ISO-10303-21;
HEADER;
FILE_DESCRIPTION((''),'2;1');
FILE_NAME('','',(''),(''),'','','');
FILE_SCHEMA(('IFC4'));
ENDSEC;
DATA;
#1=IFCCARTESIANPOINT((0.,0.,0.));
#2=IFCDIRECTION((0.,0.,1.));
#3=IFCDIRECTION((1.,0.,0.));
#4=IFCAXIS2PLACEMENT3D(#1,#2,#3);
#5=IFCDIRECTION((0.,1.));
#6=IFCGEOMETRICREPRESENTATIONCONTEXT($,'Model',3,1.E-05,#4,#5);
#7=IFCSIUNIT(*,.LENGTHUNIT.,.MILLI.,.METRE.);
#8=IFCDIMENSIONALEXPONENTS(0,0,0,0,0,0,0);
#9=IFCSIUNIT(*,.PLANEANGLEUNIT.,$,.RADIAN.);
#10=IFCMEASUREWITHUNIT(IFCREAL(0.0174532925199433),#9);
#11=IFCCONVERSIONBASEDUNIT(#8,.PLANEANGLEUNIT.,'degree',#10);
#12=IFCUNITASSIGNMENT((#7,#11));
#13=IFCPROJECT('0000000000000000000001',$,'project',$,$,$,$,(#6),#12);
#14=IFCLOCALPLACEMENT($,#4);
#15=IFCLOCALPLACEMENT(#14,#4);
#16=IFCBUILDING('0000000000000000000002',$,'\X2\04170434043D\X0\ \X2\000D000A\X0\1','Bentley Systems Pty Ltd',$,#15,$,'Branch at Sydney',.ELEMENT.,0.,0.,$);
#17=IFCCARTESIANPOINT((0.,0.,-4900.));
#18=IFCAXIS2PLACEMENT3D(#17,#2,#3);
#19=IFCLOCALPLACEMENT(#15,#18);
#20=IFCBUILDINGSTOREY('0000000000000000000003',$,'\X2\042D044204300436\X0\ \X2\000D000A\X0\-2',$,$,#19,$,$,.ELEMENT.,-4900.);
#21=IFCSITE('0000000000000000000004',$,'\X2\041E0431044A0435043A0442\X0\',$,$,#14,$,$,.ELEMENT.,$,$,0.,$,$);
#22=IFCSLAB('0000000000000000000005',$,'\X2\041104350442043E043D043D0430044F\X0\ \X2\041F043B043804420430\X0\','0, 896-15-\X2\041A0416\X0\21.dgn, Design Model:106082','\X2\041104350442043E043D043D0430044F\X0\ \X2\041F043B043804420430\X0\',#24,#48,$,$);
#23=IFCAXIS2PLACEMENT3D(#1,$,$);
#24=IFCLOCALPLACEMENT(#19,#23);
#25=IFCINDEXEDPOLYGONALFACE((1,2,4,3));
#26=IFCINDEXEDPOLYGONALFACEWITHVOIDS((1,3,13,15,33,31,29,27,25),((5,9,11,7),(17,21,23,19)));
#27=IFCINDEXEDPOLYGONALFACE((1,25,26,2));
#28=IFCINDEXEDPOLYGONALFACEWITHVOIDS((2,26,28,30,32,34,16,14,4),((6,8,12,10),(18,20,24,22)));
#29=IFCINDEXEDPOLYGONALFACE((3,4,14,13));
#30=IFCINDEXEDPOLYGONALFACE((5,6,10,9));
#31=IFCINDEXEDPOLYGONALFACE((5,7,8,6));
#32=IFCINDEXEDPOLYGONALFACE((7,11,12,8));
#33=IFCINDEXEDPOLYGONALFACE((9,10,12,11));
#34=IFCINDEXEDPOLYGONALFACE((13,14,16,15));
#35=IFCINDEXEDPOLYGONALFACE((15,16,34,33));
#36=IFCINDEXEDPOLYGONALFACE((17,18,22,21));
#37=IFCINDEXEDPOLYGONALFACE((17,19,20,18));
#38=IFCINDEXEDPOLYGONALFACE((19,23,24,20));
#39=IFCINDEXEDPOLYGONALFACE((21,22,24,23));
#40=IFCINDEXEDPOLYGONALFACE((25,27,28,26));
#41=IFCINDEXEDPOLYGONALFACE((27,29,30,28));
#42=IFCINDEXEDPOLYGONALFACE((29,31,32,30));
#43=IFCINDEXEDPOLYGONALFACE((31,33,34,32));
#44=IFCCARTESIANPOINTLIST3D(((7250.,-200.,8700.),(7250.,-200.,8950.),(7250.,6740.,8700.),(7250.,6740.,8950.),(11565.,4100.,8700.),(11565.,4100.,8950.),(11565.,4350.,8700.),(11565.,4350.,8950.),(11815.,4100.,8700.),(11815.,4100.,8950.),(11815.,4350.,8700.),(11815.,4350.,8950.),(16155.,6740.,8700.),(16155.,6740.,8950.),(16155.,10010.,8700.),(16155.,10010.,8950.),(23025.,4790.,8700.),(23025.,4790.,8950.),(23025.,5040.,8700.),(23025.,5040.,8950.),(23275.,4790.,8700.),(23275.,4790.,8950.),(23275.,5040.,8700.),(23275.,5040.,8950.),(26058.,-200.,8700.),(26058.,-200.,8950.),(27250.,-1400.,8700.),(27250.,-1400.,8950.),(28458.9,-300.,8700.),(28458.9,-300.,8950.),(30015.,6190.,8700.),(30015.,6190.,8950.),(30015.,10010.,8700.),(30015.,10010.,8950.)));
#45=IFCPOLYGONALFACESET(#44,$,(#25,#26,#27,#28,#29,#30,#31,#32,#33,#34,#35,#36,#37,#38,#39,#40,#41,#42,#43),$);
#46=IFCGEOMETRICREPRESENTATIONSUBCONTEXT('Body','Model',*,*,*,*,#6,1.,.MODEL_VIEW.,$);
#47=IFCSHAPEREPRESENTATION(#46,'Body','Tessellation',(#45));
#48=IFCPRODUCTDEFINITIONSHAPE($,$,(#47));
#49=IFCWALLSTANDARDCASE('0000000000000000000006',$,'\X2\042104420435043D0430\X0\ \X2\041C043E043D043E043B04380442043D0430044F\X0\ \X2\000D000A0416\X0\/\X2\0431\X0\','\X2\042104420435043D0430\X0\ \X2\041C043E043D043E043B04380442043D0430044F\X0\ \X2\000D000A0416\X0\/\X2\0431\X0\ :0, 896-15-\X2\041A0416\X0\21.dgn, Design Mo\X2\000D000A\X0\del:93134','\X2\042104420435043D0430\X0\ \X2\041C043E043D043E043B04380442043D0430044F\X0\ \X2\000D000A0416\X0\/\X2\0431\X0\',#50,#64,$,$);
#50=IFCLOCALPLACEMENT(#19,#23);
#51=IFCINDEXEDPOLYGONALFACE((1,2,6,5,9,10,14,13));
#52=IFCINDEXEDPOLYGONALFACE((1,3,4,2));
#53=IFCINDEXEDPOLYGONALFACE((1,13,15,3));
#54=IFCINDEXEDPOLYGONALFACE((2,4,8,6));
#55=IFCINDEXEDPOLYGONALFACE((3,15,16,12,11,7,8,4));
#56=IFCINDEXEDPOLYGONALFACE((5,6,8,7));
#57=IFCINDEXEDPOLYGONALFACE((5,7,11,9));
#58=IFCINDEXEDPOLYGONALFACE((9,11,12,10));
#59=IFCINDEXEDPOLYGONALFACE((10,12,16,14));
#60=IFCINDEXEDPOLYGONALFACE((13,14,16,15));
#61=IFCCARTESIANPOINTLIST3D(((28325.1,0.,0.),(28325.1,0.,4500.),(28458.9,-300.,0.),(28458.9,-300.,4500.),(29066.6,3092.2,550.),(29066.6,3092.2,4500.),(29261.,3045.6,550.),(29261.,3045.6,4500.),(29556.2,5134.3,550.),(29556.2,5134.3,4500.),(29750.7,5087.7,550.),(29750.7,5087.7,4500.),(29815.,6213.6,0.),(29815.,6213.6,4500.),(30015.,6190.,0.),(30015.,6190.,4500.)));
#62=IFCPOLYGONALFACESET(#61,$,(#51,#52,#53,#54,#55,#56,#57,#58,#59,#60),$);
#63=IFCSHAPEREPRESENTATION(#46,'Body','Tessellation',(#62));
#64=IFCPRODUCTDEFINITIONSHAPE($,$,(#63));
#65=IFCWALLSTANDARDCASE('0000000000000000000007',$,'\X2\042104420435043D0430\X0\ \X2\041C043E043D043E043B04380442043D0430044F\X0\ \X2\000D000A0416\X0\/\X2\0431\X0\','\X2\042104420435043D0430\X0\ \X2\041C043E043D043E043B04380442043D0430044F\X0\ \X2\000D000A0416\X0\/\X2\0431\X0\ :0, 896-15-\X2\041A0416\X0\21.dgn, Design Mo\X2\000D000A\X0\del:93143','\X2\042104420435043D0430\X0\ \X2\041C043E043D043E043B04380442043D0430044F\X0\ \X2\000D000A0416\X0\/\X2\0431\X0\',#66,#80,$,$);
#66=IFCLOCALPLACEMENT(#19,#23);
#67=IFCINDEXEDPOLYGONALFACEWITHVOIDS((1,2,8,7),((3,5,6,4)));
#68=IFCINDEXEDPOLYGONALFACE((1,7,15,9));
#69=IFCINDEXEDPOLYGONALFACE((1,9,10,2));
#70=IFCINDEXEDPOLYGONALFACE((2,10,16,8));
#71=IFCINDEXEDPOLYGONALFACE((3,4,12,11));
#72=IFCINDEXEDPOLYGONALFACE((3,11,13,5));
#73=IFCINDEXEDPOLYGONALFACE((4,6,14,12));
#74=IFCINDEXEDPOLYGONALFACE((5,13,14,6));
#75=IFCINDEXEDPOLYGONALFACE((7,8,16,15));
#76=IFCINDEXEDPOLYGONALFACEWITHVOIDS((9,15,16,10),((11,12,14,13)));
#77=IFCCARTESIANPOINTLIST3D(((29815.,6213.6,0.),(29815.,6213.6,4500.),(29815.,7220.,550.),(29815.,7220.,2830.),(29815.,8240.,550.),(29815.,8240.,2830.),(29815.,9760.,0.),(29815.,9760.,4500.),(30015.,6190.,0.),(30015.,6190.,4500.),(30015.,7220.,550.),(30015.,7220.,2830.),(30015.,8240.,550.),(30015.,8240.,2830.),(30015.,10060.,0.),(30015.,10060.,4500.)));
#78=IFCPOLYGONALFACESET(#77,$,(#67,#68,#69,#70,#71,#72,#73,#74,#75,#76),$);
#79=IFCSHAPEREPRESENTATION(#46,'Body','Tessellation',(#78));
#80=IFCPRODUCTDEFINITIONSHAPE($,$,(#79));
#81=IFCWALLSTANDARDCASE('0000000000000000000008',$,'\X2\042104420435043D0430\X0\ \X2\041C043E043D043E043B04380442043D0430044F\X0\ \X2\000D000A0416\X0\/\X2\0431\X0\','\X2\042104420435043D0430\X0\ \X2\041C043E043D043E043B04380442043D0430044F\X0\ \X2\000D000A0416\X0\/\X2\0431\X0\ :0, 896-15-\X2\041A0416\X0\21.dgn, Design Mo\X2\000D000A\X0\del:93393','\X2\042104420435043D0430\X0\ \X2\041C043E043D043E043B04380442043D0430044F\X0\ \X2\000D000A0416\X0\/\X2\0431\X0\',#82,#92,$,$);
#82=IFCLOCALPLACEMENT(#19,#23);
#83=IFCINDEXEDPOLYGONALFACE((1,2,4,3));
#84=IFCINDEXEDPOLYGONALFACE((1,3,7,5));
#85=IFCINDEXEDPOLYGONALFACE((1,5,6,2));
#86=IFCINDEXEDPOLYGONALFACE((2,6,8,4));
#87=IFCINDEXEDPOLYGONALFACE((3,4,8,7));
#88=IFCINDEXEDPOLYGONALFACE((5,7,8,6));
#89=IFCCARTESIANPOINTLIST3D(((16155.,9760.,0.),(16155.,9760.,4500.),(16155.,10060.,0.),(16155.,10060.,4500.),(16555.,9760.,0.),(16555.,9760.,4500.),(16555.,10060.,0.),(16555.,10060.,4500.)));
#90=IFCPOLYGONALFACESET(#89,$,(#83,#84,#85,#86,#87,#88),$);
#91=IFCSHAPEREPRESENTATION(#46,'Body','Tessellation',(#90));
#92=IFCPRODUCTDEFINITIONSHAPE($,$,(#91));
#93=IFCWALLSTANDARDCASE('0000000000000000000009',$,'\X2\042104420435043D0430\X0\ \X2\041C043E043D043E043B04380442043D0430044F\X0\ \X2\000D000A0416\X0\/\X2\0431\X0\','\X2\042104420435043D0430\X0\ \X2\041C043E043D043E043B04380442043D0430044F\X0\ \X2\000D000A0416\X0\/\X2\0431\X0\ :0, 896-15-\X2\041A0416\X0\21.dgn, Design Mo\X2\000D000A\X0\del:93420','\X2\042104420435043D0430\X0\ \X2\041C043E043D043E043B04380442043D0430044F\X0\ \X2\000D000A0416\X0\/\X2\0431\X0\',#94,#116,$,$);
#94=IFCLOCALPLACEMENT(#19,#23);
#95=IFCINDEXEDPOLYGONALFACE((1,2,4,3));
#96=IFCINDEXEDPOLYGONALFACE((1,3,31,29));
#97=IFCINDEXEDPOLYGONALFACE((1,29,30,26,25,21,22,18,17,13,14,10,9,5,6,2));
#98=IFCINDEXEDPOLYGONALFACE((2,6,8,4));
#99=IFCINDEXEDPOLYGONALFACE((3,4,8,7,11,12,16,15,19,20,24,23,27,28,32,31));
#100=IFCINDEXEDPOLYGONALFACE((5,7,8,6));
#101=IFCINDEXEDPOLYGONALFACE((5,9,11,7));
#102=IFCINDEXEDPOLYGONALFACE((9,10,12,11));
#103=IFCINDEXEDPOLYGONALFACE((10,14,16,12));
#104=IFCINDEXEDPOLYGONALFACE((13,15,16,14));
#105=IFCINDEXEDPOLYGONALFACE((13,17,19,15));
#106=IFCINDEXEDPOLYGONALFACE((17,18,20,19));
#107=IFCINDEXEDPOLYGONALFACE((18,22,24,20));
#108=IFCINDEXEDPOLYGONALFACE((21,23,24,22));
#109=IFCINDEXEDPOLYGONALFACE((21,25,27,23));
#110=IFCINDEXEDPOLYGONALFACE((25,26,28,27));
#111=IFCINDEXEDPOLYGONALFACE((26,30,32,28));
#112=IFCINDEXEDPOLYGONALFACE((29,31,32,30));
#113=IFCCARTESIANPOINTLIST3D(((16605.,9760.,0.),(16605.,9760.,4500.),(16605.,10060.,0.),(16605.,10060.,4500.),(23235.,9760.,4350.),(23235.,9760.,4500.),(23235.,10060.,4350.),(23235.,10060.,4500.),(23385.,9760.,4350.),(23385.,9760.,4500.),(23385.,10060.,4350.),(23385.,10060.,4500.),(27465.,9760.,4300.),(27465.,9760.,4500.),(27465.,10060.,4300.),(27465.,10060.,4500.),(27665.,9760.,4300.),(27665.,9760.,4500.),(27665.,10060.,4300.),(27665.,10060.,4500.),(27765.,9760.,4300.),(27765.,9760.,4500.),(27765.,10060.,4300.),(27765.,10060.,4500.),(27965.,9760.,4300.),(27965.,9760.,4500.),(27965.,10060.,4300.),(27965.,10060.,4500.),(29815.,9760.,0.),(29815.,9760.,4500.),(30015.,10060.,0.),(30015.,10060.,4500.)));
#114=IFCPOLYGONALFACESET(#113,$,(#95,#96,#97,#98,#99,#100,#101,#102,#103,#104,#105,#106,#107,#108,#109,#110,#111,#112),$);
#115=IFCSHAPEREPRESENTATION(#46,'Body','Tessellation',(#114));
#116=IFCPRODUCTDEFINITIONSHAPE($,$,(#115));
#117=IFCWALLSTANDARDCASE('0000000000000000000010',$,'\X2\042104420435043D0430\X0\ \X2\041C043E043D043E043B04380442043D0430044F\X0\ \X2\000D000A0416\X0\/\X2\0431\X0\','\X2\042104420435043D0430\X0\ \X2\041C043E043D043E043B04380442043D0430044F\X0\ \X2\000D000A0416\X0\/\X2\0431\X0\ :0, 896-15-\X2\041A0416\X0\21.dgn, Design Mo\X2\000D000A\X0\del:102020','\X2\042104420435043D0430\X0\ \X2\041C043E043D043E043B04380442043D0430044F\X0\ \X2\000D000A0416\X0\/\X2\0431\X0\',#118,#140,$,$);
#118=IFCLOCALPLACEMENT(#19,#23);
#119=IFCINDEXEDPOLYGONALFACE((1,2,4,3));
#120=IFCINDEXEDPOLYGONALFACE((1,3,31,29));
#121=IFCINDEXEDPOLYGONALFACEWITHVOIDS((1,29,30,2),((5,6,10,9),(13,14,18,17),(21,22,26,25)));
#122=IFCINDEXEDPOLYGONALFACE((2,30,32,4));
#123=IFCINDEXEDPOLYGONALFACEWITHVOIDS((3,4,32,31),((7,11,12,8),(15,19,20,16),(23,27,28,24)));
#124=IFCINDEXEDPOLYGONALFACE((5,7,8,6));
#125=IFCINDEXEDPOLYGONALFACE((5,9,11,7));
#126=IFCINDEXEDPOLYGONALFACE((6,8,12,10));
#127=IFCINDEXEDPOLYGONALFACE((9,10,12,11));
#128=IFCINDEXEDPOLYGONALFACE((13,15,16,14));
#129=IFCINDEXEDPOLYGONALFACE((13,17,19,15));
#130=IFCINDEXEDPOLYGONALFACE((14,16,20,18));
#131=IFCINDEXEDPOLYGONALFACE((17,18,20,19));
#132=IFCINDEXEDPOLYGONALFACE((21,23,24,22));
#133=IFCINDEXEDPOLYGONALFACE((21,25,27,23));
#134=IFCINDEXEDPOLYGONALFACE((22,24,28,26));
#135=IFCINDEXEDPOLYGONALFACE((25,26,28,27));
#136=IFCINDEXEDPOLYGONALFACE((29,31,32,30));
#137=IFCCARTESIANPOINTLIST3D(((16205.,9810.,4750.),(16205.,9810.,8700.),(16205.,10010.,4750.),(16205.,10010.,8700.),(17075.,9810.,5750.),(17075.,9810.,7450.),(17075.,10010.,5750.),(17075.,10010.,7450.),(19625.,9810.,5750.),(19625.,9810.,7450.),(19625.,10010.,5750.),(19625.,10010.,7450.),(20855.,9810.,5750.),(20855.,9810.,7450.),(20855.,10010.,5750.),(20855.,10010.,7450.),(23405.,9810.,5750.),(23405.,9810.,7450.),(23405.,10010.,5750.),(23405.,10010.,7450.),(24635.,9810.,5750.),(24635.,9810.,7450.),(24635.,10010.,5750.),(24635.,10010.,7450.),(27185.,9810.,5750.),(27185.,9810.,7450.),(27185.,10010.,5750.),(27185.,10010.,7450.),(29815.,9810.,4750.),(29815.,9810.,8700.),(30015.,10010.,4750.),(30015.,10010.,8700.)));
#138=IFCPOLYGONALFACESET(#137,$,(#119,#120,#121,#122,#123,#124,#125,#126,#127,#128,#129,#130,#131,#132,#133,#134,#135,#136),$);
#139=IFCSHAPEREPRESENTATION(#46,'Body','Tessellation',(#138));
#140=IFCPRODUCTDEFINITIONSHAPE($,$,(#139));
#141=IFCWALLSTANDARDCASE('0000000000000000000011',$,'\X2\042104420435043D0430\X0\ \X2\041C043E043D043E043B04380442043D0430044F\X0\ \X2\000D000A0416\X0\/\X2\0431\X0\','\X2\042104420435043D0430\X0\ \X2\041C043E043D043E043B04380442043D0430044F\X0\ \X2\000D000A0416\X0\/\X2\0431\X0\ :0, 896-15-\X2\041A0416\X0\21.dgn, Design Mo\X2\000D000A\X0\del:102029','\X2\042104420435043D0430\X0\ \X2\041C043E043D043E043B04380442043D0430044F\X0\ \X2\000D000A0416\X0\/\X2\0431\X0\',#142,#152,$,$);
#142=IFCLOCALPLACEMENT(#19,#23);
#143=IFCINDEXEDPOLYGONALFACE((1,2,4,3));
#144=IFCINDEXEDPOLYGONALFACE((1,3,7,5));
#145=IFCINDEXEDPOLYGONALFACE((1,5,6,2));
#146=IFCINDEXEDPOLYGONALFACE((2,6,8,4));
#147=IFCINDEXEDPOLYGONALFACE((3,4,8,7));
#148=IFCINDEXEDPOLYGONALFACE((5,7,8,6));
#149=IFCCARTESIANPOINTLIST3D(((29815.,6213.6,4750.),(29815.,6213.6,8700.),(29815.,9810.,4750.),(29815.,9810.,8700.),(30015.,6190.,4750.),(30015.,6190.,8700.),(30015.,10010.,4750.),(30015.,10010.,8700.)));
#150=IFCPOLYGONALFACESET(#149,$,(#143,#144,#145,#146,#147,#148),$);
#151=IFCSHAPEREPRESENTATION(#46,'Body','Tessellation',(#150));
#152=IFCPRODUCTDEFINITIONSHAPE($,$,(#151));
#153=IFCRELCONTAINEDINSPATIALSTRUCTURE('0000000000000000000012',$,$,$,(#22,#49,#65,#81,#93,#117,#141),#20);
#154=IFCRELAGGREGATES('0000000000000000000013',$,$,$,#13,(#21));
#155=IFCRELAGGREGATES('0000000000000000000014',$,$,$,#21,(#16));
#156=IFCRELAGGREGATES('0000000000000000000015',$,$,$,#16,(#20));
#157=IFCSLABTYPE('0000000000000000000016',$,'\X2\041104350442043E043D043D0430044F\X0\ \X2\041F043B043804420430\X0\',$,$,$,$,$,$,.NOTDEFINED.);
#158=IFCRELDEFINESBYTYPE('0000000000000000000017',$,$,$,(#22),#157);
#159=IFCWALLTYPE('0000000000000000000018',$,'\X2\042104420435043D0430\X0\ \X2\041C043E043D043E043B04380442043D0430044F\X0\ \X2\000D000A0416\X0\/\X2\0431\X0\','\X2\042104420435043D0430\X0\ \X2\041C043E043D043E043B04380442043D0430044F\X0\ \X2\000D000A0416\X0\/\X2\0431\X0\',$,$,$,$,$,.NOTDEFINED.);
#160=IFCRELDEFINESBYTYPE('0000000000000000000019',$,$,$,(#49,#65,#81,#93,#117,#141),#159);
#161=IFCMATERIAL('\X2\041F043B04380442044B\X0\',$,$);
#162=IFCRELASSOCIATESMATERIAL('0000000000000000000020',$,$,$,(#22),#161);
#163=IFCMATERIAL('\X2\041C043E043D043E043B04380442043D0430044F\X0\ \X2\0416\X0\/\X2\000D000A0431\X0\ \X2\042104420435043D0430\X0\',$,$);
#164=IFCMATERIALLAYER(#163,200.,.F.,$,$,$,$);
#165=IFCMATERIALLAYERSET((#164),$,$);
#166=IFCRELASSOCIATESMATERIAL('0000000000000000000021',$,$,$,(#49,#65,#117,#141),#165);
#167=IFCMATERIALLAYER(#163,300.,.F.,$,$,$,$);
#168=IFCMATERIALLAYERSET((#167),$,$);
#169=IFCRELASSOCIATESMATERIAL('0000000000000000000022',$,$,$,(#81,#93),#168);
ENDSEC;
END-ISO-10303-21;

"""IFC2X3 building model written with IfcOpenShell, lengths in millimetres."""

from ifc_helpers import new_model, entity, si_unit, converted_unit, direction, frame, frame_2d, origin_with_axes, place, context, subcontext, project, spatial, polyline, rectangle, outline, extrude, material, layer, layer_set, layer_usage, type_object, element, save


model = new_model("IFC2X3")

# Units and contexts
model_context = context("Model", 3, precision=1e-05, world=origin_with_axes(), true_north=direction((0.0, 1.0)))
body_context = subcontext(model_context, "Body", "Model", "MODEL_VIEW", scale=1.0)
ifc_project = project(units=[si_unit("LENGTHUNIT", "METRE", prefix="MILLI"), converted_unit("PLANEANGLEUNIT", "degree", entity("IfcReal", 0.0174532925199433), si_unit("PLANEANGLEUNIT", "RADIAN"), dimensions=[0, 0, 0, 0, 0, 0, 0])], contexts=[model_context])

# Site, building, storey
site_placement = place(None, origin_with_axes())
site = spatial("IfcSite", under=ifc_project, at=site_placement, Name="Объект", CompositionType="ELEMENT", RefElevation=0.0)
building_placement = place(site_placement, origin_with_axes())
building = spatial("IfcBuilding", under=site, at=building_placement, Name="Здн \r\n1", Description="Bentley Systems Pty Ltd", LongName="Branch at Sydney", CompositionType="ELEMENT", ElevationOfRefHeight=0.0, ElevationOfTerrain=0.0)
storey_placement = place(building_placement, frame((0.0, 0.0, -4900.0), z_axis=(0.0, 0.0, 1.0), x_axis=(1.0, 0.0, 0.0)))
storey = spatial("IfcBuildingStorey", under=building, at=storey_placement, Name="Этаж \r\n-2", CompositionType="ELEMENT", Elevation=-4900.0)

# Slab, openings
ifc_material_1 = material(Name="Плиты")
slab_type = type_object("IfcSlabType", Name="Бетонная Плита", PredefinedType="NOTDEFINED")
slab_placement = place(storey_placement, frame((30015.0, 10010.0, 8950.0), z_axis=(0.0, 0.0, -1.0), x_axis=(0.0, -1.0, 0.0)))
slab = element("IfcSlab", 1, at=slab_placement, inside=storey, type_object=slab_type, material=ifc_material_1, Name="Бетонная Плита", Description="0, 896-15-КЖ21.dgn, Design Model:106082", ObjectType="Бетонная Плита", context=body_context, shape_type="SweptSolid", body=[
    extrude(outline(polyline([(0.0, 0.0), (3820.0, 0.0), (10310.0, 1556.1), (11410.0, 2765.0), (10210.0, 3957.0), (10210.0, 22765.0), (3270.0, 22765.0), (3270.0, 13860.0), (0.0, 13860.0), (0.0, 0.0)])), origin_with_axes(), (0.0, 0.0, 1.0), 250.0),
])
opening_1_placement = place(slab_placement, frame((4970.0, 6740.0, 0.0), z_axis=(0.0, 0.0, 1.0), x_axis=(1.0, 0.0, 0.0)))
element("IfcOpeningElement", 2, at=opening_1_placement, cuts=slab, ObjectType="Opening", context=body_context, shape_type="SweptSolid", body=[
    extrude(rectangle(XDim=250.0, YDim=250.0, at=frame_2d((-125.0, 125.0), x_axis=(0.0, 1.0))), frame((0.0, 0.0, 375.0), z_axis=(0.0, 0.0, -1.0), x_axis=(-1.0, 0.0, 0.0)), (0.0, 0.0, 1.0), 750.0),
])
opening_2_placement = place(slab_placement, frame((5660.0, 18200.0, 0.0), z_axis=(0.0, 0.0, 1.0), x_axis=(1.0, 0.0, 0.0)))
element("IfcOpeningElement", 3, at=opening_2_placement, cuts=slab, ObjectType="Opening", context=body_context, shape_type="SweptSolid", body=[
    extrude(rectangle(XDim=250.0, YDim=250.0, at=frame_2d((-125.0, 125.0), x_axis=(0.0, 1.0))), frame((0.0, 0.0, 375.0), z_axis=(0.0, 0.0, -1.0), x_axis=(-1.0, 0.0, 0.0)), (0.0, 0.0, 1.0), 750.0),
])

# Walls, openings
ifc_material_2 = material(Name="Монолитная Ж/\r\nб Стена")
ifc_layer_1 = layer(ifc_material_2, 200.0, ventilated=False)
ifc_layer_set_1 = layer_set([ifc_layer_1])
ifc_layer_usage_1 = layer_usage(ifc_layer_set_1, "AXIS2", "POSITIVE", 0.0)
wall_type = type_object("IfcWallType", Name="Стена Монолитная \r\nЖ/б", Description="Стена Монолитная \r\nЖ/б", PredefinedType="NOTDEFINED")
wall_1_placement = place(storey_placement, frame((28458.9, -300.0, 0.0), z_axis=(0.0, 0.0, 1.0), x_axis=(0.233165, 0.972437, 0.0)))
wall_1 = element("IfcWallStandardCase", 4, at=wall_1_placement, inside=storey, type_object=wall_type, material=ifc_layer_usage_1, Name="Стена Монолитная \r\nЖ/б", Description="Стена Монолитная \r\nЖ/б :0, 896-15-КЖ21.dgn, Design Mo\r\ndel:93134", ObjectType="Стена Монолитная \r\nЖ/б", context=body_context, shape_type="SweptSolid", body=[
    extrude(outline(polyline([(6650.3, 200.0), (260.5, 200.0), (0.0, 0.0), (6674.0, 0.0), (6650.3, 200.0)])), origin_with_axes(), (0.0, 0.0, 1.0), 4500.0),
])
opening_3_placement = place(wall_1_placement, frame((3440.4, 0.0, 550.0), z_axis=(0.0, 0.0, 1.0), x_axis=(1.0, 0.0, 0.0)))
element("IfcOpeningElement", 5, at=opening_3_placement, cuts=wall_1, ObjectType="Opening", context=body_context, shape_type="SweptSolid", body=[
    extrude(rectangle(XDim=3950.0, YDim=2100.0, at=frame_2d((-1050.0, 1975.0), x_axis=(0.0, -1.0))), frame((0.0, 0.0, 0.0), z_axis=(0.0, 1.0, 0.0), x_axis=(-1.0, 0.0, 0.0)), (0.0, 0.0, 1.0), 200.0),
])
wall_2_placement = place(storey_placement, frame((30015.0, 6190.0, 0.0), z_axis=(0.0, 0.0, 1.0), x_axis=(0.0, 1.0, 0.0)))
wall_2 = element("IfcWallStandardCase", 6, at=wall_2_placement, inside=storey, type_object=wall_type, material=ifc_layer_usage_1, Name="Стена Монолитная \r\nЖ/б", Description="Стена Монолитная \r\nЖ/б :0, 896-15-КЖ21.dgn, Design Mo\r\ndel:93143", ObjectType="Стена Монолитная \r\nЖ/б", context=body_context, shape_type="SweptSolid", body=[
    extrude(outline(polyline([(3570.0, 200.0), (23.6, 200.0), (0.0, 0.0), (3870.0, 0.0), (3570.0, 200.0)])), origin_with_axes(), (0.0, 0.0, 1.0), 4500.0),
])
opening_4_placement = place(wall_2_placement, frame((1030.0, 0.0, 550.0), z_axis=(0.0, 0.0, 1.0), x_axis=(1.0, 0.0, 0.0)))
element("IfcOpeningElement", 7, at=opening_4_placement, cuts=wall_2, ObjectType="Opening", context=body_context, shape_type="SweptSolid", body=[
    extrude(rectangle(XDim=2280.0, YDim=1020.0, at=frame_2d((-510.0, 1140.0), x_axis=(0.0, -1.0))), frame((0.0, 0.0, 0.0), z_axis=(0.0, 1.0, 0.0), x_axis=(-1.0, 0.0, 0.0)), (0.0, 0.0, 1.0), 200.0),
])

# Wall
ifc_layer_2 = layer(ifc_material_2, 300.0, ventilated=False)
ifc_layer_set_2 = layer_set([ifc_layer_2])
ifc_layer_usage_2 = layer_usage(ifc_layer_set_2, "AXIS2", "POSITIVE", 0.0)
wall_3_placement = place(storey_placement, frame((16555.0, 10060.0, 0.0), z_axis=(0.0, 0.0, 1.0), x_axis=(-1.0, 0.0, 0.0)))
element("IfcWallStandardCase", 8, at=wall_3_placement, inside=storey, type_object=wall_type, material=ifc_layer_usage_2, Name="Стена Монолитная \r\nЖ/б", Description="Стена Монолитная \r\nЖ/б :0, 896-15-КЖ21.dgn, Design Mo\r\ndel:93393", ObjectType="Стена Монолитная \r\nЖ/б", context=body_context, shape_type="SweptSolid", body=[
    extrude(rectangle(XDim=400.0, YDim=300.0, at=frame_2d((200.0, 150.0), x_axis=(1.0, 0.0))), origin_with_axes(), (0.0, 0.0, 1.0), 4500.0),
])

# Walls, openings
wall_4_placement = place(storey_placement, frame((30015.0, 10060.0, 0.0), z_axis=(0.0, 0.0, 1.0), x_axis=(-1.0, 0.0, 0.0)))
wall_4 = element("IfcWallStandardCase", 9, at=wall_4_placement, inside=storey, type_object=wall_type, material=ifc_layer_usage_2, Name="Стена Монолитная \r\nЖ/б", Description="Стена Монолитная \r\nЖ/б :0, 896-15-КЖ21.dgn, Design Mo\r\ndel:93420", ObjectType="Стена Монолитная \r\nЖ/б", context=body_context, shape_type="SweptSolid", body=[
    extrude(outline(polyline([(200.0, 300.0), (0.0, 0.0), (13410.0, 0.0), (13410.0, 300.0), (200.0, 300.0)])), origin_with_axes(), (0.0, 0.0, 1.0), 4500.0),
])
opening_5_placement = place(wall_4_placement, frame((6630.0, 0.0, 4350.0), z_axis=(0.0, 0.0, 1.0), x_axis=(1.0, 0.0, 0.0)))
element("IfcOpeningElement", 10, at=opening_5_placement, cuts=wall_4, ObjectType="Opening", context=body_context, shape_type="SweptSolid", body=[
    extrude(rectangle(XDim=150.0, YDim=150.0, at=frame_2d((-75.0, 75.0), x_axis=(0.0, -1.0))), frame((0.0, 0.0, 0.0), z_axis=(0.0, 1.0, 0.0), x_axis=(-1.0, 0.0, 0.0)), (0.0, 0.0, 1.0), 300.0),
])
opening_6_placement = place(wall_4_placement, frame((2350.0, 0.0, 4300.0), z_axis=(0.0, 0.0, 1.0), x_axis=(1.0, 0.0, 0.0)))
element("IfcOpeningElement", 11, at=opening_6_placement, cuts=wall_4, ObjectType="Opening", context=body_context, shape_type="SweptSolid", body=[
    extrude(rectangle(XDim=200.0, YDim=200.0, at=frame_2d((-100.0, 100.0), x_axis=(0.0, -1.0))), frame((0.0, 0.0, 0.0), z_axis=(0.0, 1.0, 0.0), x_axis=(-1.0, 0.0, 0.0)), (0.0, 0.0, 1.0), 300.0),
])
opening_7_placement = place(wall_4_placement, frame((2050.0, 0.0, 4300.0), z_axis=(0.0, 0.0, 1.0), x_axis=(1.0, 0.0, 0.0)))
element("IfcOpeningElement", 12, at=opening_7_placement, cuts=wall_4, ObjectType="Opening", context=body_context, shape_type="SweptSolid", body=[
    extrude(rectangle(XDim=200.0, YDim=200.0, at=frame_2d((-100.0, 100.0), x_axis=(0.0, -1.0))), frame((0.0, 0.0, 0.0), z_axis=(0.0, 1.0, 0.0), x_axis=(-1.0, 0.0, 0.0)), (0.0, 0.0, 1.0), 300.0),
])
wall_5_placement = place(storey_placement, frame((30015.0, 10010.0, 4750.0), z_axis=(0.0, 0.0, 1.0), x_axis=(-1.0, 0.0, 0.0)))
wall_5 = element("IfcWallStandardCase", 13, at=wall_5_placement, inside=storey, type_object=wall_type, material=ifc_layer_usage_1, Name="Стена Монолитная \r\nЖ/б", Description="Стена Монолитная \r\nЖ/б :0, 896-15-КЖ21.dgn, Design Mo\r\ndel:102020", ObjectType="Стена Монолитная \r\nЖ/б", context=body_context, shape_type="SweptSolid", body=[
    extrude(outline(polyline([(200.0, 200.0), (0.0, 0.0), (13810.0, 0.0), (13810.0, 200.0), (200.0, 200.0)])), origin_with_axes(), (0.0, 0.0, 1.0), 3950.0),
])
opening_8_placement = place(wall_5_placement, frame((10390.0, 0.0, 1000.0), z_axis=(0.0, 0.0, 1.0), x_axis=(1.0, 0.0, 0.0)))
element("IfcOpeningElement", 14, at=opening_8_placement, cuts=wall_5, ObjectType="Opening", context=body_context, shape_type="SweptSolid", body=[
    extrude(rectangle(XDim=1700.0, YDim=2550.0, at=frame_2d((-1275.0, 850.0), x_axis=(0.0, -1.0))), frame((0.0, 0.0, 0.0), z_axis=(0.0, 1.0, 0.0), x_axis=(-1.0, 0.0, 0.0)), (0.0, 0.0, 1.0), 200.0),
])
opening_9_placement = place(wall_5_placement, frame((6610.0, 0.0, 1000.0), z_axis=(0.0, 0.0, 1.0), x_axis=(1.0, 0.0, 0.0)))
element("IfcOpeningElement", 15, at=opening_9_placement, cuts=wall_5, ObjectType="Opening", context=body_context, shape_type="SweptSolid", body=[
    extrude(rectangle(XDim=1700.0, YDim=2550.0, at=frame_2d((-1275.0, 850.0), x_axis=(0.0, -1.0))), frame((0.0, 0.0, 0.0), z_axis=(0.0, 1.0, 0.0), x_axis=(-1.0, 0.0, 0.0)), (0.0, 0.0, 1.0), 200.0),
])
opening_10_placement = place(wall_5_placement, frame((2830.0, 0.0, 1000.0), z_axis=(0.0, 0.0, 1.0), x_axis=(1.0, 0.0, 0.0)))
element("IfcOpeningElement", 16, at=opening_10_placement, cuts=wall_5, ObjectType="Opening", context=body_context, shape_type="SweptSolid", body=[
    extrude(rectangle(XDim=1700.0, YDim=2550.0, at=frame_2d((-1275.0, 850.0), x_axis=(0.0, -1.0))), frame((0.0, 0.0, 0.0), z_axis=(0.0, 1.0, 0.0), x_axis=(-1.0, 0.0, 0.0)), (0.0, 0.0, 1.0), 200.0),
])

# Wall
wall_6_placement = place(storey_placement, frame((30015.0, 10010.0, 4750.0), z_axis=(0.0, 0.0, 1.0), x_axis=(0.0, -1.0, 0.0)))
element("IfcWallStandardCase", 17, at=wall_6_placement, inside=storey, type_object=wall_type, material=ifc_layer_usage_1, Name="Стена Монолитная \r\nЖ/б", Description="Стена Монолитная \r\nЖ/б :0, 896-15-КЖ21.dgn, Design Mo\r\ndel:102029", ObjectType="Стена Монолитная \r\nЖ/б", context=body_context, shape_type="SweptSolid", body=[
    extrude(outline(polyline([(3820.0, 0.0), (0.0, 0.0), (200.0, -200.0), (3796.4, -200.0), (3820.0, 0.0)])), origin_with_axes(), (0.0, 0.0, 1.0), 3950.0),
])

save(model, "model.ifc")
